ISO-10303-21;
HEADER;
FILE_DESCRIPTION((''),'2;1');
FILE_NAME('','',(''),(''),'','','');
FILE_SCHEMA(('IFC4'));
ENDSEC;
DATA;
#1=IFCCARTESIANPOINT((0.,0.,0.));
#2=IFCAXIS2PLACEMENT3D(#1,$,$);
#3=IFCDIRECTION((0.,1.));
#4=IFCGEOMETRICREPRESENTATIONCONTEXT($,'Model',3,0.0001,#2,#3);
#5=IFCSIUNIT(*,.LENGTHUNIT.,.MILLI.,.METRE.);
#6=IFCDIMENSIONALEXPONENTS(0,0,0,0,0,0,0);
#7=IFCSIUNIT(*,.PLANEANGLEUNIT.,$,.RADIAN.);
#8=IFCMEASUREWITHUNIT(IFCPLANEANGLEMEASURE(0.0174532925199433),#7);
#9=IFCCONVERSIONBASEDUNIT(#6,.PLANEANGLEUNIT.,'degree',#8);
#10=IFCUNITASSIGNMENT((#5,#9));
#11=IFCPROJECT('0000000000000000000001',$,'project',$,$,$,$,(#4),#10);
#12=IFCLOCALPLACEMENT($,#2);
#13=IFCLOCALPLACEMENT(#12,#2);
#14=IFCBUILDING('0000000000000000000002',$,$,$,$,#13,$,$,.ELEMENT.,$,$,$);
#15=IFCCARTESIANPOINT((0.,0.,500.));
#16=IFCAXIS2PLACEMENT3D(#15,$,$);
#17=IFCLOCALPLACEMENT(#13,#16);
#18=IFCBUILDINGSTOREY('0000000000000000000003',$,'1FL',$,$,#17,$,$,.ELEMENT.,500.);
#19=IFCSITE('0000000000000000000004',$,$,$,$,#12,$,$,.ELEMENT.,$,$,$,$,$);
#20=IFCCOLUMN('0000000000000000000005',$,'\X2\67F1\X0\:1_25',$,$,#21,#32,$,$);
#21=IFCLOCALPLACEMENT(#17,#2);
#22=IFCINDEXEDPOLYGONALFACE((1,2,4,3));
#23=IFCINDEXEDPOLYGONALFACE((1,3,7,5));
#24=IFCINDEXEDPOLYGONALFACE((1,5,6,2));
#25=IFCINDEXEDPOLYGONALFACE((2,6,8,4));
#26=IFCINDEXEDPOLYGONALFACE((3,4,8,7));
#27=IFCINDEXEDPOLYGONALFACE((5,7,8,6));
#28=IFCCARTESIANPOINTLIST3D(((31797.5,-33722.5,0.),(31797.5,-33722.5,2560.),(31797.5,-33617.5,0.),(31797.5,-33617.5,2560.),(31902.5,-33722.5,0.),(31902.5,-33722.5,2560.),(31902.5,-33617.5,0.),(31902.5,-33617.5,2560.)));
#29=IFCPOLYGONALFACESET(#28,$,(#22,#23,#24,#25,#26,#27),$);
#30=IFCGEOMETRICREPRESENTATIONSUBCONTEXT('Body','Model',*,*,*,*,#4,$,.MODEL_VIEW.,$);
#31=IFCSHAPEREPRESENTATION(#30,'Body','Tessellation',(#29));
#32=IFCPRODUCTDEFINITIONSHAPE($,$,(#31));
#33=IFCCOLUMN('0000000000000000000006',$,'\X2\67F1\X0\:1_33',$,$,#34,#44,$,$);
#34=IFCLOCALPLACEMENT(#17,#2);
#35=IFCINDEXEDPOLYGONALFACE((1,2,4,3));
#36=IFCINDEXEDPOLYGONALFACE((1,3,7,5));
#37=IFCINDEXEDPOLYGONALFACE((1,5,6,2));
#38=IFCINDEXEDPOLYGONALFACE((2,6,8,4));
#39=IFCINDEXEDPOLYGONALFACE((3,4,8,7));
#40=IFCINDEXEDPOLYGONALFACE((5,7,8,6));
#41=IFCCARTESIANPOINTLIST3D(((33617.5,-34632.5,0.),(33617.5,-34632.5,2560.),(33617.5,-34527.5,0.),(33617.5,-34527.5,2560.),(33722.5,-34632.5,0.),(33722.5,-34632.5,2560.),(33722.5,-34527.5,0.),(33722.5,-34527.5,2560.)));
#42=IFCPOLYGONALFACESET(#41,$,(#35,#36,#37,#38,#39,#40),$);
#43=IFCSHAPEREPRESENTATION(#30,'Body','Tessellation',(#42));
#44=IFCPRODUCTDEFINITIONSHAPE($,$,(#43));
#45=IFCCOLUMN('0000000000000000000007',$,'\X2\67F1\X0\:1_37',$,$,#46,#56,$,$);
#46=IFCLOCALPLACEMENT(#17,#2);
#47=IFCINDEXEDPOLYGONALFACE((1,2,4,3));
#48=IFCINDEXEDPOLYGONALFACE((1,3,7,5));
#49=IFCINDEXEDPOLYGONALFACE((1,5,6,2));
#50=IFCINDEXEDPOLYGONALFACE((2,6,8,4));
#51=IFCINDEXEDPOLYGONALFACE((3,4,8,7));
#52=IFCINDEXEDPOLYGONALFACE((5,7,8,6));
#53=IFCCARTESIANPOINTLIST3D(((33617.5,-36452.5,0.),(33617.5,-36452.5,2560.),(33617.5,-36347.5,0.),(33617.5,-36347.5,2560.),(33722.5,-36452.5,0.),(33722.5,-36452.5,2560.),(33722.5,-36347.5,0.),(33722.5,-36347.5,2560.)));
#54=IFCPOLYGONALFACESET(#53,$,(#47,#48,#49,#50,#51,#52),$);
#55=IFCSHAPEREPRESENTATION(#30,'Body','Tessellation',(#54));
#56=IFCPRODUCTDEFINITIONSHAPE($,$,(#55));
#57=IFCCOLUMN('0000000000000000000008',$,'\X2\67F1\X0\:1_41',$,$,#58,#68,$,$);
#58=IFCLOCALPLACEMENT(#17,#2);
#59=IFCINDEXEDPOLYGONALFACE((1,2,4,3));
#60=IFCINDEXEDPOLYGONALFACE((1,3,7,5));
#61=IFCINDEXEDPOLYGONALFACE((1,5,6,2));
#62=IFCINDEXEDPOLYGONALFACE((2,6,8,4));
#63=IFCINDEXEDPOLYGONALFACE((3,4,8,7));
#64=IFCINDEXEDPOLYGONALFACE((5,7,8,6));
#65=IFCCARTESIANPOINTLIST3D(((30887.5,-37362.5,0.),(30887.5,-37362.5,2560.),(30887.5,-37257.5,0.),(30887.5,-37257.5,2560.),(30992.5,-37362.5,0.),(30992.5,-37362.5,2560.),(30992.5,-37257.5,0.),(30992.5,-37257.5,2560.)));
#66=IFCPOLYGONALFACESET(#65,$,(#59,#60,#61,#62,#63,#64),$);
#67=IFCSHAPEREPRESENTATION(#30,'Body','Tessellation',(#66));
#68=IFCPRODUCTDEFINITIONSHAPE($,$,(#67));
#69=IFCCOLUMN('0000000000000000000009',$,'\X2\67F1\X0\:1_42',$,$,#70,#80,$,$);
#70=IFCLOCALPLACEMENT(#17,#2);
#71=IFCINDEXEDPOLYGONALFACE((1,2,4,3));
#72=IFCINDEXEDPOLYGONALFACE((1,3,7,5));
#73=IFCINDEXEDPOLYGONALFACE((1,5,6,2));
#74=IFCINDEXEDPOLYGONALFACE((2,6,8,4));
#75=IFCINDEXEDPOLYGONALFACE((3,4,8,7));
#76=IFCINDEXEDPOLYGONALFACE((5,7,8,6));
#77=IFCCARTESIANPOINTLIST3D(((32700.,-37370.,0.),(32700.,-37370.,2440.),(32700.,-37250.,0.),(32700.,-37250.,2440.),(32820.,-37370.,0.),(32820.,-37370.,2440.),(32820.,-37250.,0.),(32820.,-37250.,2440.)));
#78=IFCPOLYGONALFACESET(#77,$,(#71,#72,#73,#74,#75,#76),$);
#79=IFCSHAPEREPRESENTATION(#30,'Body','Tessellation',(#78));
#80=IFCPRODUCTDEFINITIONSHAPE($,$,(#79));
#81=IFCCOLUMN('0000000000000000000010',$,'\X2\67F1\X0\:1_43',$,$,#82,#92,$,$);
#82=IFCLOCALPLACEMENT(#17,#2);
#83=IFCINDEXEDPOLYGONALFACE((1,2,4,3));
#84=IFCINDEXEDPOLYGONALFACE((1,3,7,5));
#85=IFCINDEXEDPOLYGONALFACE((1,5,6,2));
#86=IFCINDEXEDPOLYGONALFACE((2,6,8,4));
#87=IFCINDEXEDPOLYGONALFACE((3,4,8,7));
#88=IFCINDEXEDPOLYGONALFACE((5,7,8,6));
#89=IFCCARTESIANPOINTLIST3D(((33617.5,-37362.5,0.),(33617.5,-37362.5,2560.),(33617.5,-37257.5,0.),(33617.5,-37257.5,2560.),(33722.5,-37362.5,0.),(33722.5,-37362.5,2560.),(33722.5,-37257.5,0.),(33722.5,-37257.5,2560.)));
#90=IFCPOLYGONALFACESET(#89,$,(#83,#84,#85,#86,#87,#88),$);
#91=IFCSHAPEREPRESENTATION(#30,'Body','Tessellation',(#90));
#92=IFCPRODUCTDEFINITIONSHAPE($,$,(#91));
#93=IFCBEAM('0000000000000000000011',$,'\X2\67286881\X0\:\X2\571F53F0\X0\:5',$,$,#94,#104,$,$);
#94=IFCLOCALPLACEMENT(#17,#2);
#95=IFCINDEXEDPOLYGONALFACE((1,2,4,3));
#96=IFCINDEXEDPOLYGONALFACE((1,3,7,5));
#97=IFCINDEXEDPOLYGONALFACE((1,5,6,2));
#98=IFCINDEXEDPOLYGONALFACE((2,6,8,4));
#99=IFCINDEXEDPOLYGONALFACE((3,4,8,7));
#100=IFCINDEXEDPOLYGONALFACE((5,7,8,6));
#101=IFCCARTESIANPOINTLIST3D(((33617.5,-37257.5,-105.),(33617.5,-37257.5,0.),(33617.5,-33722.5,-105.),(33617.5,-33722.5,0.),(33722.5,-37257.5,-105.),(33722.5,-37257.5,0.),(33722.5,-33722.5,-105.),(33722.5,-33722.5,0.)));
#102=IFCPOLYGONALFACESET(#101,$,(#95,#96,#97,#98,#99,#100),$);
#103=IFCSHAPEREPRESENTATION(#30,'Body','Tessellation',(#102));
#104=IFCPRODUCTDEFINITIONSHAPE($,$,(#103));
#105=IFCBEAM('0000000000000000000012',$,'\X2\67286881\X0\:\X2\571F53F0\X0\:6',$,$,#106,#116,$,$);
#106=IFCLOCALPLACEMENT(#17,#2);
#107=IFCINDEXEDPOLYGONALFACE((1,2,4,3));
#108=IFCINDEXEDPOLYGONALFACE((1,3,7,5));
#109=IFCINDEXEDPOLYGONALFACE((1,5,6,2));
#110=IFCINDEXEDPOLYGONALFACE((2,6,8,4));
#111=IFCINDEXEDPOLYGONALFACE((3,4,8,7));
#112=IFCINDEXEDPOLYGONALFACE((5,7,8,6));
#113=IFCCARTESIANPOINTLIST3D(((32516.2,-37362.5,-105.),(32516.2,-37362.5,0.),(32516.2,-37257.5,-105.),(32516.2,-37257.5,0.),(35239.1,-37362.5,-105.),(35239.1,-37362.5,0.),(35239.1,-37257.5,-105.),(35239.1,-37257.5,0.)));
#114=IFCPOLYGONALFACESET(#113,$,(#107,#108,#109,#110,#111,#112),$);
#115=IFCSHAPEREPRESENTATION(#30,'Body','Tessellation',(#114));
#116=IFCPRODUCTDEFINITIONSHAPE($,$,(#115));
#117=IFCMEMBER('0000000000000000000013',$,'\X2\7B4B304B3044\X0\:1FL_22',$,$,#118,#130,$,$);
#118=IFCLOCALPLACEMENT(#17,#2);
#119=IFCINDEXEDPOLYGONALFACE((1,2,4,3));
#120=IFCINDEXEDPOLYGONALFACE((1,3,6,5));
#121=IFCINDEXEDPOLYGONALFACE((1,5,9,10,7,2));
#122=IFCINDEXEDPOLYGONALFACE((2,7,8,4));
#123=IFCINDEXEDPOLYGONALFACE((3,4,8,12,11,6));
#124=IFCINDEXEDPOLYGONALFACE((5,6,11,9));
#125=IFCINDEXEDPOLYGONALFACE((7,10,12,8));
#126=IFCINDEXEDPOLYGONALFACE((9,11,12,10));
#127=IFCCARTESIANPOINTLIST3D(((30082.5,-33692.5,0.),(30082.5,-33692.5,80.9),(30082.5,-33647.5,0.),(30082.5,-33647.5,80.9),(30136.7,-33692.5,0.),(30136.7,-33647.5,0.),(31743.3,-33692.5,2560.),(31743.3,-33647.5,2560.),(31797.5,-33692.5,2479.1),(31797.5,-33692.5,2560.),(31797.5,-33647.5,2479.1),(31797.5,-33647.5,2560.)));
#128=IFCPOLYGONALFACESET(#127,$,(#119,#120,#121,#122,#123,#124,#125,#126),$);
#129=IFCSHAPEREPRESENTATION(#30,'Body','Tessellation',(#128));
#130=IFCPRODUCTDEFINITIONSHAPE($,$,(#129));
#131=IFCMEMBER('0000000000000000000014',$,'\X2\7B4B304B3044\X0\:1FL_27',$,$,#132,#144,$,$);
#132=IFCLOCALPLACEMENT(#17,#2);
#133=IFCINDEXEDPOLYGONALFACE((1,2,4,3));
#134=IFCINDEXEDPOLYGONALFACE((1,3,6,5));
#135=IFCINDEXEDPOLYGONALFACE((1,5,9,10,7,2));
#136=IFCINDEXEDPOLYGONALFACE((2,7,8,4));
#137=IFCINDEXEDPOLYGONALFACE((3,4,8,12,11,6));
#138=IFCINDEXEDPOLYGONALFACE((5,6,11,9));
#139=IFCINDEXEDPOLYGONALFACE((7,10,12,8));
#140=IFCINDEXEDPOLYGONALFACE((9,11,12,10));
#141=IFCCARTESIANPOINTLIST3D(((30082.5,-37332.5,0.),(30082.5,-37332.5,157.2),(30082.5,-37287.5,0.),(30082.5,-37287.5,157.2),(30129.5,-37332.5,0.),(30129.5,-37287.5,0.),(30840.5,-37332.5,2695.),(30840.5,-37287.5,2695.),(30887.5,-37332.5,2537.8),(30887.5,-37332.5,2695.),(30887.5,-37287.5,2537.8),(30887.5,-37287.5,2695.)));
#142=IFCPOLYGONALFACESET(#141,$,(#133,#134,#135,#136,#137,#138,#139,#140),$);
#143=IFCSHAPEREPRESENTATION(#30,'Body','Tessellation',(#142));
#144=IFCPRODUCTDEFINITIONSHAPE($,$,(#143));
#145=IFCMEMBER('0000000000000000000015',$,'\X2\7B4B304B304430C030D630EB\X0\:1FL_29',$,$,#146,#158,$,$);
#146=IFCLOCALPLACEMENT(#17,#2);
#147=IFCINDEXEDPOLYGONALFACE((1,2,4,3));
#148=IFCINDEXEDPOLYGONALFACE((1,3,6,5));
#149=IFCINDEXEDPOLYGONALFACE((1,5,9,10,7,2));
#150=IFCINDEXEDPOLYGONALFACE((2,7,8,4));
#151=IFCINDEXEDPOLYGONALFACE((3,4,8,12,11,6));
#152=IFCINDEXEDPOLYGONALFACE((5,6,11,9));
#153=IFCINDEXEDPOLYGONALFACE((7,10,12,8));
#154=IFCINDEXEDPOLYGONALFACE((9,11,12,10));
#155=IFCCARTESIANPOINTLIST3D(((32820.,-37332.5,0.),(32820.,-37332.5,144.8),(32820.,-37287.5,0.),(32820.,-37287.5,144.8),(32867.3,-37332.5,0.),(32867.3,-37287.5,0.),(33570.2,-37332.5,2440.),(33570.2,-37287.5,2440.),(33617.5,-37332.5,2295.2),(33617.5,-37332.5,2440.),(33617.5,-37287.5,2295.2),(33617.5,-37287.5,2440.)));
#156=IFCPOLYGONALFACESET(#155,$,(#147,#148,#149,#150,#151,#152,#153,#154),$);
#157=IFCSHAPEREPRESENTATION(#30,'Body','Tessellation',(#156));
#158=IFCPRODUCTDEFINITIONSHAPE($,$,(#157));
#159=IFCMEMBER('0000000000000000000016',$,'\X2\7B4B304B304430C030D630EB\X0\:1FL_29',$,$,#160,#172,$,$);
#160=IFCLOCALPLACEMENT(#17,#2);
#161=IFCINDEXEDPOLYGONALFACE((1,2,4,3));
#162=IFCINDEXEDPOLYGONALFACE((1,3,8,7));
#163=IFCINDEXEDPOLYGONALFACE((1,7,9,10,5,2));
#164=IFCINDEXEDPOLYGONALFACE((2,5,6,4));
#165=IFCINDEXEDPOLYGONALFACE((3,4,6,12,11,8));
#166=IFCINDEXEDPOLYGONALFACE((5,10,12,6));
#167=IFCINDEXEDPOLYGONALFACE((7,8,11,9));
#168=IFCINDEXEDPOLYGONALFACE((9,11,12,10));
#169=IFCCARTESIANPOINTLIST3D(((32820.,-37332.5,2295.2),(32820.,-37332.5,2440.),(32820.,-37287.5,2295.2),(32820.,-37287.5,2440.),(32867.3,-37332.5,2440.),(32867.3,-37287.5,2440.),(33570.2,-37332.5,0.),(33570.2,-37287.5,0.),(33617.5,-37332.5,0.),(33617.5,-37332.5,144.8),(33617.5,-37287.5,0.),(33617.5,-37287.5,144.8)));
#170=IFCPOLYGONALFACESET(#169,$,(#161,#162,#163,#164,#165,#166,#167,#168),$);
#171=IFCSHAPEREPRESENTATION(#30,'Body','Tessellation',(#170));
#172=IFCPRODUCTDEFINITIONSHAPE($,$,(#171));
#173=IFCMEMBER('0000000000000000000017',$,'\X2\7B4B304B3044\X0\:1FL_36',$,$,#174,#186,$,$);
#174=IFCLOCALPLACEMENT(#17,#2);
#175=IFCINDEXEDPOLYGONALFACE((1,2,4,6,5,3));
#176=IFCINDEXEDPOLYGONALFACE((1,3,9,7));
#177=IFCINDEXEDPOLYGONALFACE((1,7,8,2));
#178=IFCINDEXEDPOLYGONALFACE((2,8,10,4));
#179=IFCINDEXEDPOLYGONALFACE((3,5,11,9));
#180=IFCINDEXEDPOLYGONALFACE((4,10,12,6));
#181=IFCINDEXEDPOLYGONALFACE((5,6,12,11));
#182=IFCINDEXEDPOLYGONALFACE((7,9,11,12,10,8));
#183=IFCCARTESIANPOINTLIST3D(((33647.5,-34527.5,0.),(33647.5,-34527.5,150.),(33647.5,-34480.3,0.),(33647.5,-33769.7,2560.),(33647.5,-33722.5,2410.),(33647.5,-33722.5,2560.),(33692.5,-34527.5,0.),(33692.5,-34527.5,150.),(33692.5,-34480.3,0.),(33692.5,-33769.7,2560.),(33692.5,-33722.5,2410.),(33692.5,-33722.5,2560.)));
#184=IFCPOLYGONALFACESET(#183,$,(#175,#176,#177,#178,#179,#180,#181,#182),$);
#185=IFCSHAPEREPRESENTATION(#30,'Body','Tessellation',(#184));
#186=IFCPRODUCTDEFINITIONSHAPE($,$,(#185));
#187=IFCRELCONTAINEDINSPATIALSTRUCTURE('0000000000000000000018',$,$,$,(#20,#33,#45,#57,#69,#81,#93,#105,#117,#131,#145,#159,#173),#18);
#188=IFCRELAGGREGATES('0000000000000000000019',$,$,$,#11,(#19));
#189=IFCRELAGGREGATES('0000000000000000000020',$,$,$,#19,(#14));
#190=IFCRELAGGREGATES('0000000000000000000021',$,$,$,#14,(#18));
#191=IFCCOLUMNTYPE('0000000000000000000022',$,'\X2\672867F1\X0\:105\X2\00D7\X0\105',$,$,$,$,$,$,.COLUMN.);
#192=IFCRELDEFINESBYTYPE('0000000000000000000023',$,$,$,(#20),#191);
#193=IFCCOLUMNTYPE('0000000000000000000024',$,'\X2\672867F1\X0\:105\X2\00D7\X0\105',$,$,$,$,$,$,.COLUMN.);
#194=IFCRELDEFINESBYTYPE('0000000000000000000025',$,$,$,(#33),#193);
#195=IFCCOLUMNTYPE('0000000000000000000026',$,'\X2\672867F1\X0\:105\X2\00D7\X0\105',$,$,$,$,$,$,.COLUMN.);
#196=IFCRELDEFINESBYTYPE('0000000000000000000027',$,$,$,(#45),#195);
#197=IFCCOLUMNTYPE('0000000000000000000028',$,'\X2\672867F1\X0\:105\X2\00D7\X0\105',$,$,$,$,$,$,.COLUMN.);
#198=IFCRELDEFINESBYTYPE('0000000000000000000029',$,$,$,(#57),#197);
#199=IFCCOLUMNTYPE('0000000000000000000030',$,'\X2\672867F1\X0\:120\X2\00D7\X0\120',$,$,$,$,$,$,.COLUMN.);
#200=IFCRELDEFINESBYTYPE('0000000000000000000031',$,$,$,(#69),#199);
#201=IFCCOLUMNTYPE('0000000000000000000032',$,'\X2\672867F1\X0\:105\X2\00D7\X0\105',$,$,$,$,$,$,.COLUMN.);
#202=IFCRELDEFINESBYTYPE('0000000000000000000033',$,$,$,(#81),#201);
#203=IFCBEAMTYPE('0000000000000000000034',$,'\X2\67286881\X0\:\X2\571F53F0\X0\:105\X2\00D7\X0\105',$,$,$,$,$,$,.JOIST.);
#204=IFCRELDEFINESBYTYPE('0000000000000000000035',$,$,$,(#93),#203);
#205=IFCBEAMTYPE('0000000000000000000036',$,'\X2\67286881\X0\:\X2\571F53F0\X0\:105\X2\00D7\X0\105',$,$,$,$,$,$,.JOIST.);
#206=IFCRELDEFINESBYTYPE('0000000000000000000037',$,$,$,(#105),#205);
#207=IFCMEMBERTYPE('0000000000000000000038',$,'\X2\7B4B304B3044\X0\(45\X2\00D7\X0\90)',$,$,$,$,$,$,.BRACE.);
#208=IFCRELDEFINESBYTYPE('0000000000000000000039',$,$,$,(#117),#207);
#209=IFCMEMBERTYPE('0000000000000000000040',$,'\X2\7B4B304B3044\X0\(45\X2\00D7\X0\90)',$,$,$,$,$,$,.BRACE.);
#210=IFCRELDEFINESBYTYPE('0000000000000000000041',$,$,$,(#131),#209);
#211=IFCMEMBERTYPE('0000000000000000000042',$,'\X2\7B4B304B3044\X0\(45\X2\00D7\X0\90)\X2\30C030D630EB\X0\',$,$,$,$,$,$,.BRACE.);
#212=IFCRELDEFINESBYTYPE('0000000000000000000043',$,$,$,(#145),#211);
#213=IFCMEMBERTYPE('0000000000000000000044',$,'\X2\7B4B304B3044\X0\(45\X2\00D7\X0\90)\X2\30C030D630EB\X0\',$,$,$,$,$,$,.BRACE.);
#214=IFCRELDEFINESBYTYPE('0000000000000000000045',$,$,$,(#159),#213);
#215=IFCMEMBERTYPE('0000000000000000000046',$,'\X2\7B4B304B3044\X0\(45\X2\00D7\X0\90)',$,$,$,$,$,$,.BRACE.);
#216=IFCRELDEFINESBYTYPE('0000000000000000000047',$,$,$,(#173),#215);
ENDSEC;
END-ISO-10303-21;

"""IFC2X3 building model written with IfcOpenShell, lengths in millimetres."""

from ifc_helpers import new_model, entity, si_unit, converted_unit, direction, frame, origin, origin_with_axes, origin_2d, place, context, subcontext, project, spatial, polyline, rectangle, outline, extrude, type_object, element, save


model = new_model("IFC2X3")

# Units and contexts
model_context = context("Model", 3, precision=0.0001, world=origin(), true_north=direction((0.0, 1.0)))
body_context = subcontext(model_context, "Body", "Model", "MODEL_VIEW")
ifc_project = project(units=[si_unit("LENGTHUNIT", "METRE", prefix="MILLI"), converted_unit("PLANEANGLEUNIT", "degree", entity("IfcPlaneAngleMeasure", 0.0174532925199433), si_unit("PLANEANGLEUNIT", "RADIAN"), dimensions=[0, 0, 0, 0, 0, 0, 0])], contexts=[model_context])

# Site, building, storey
site_placement = place(None, origin())
site = spatial("IfcSite", under=ifc_project, at=site_placement, CompositionType="ELEMENT")
building_placement = place(site_placement, origin())
building = spatial("IfcBuilding", under=site, at=building_placement, CompositionType="ELEMENT")
storey_placement = place(building_placement, frame((0.0, 0.0, 500.0)))
storey = spatial("IfcBuildingStorey", under=building, at=storey_placement, Name="1FL", CompositionType="ELEMENT", Elevation=500.0)

# Columns
column_type_1 = type_object("IfcColumnType", Name="木柱:105×105", PredefinedType="COLUMN")
column_1_placement = place(storey_placement, frame((31850.0, -33670.0, 0.0)))
element("IfcColumn", 1, at=column_1_placement, inside=storey, type_object=column_type_1, Name="柱:1_25", context=body_context, shape_type="SweptSolid", body=[
    extrude(rectangle(XDim=105.0, YDim=105.0, at=origin_2d()), origin_with_axes(), (0.0, 0.0, 1.0), 2560.0),
])
column_type_2 = type_object("IfcColumnType", Name="木柱:105×105", PredefinedType="COLUMN")
column_2_placement = place(storey_placement, frame((33670.0, -34580.0, 0.0)))
element("IfcColumn", 2, at=column_2_placement, inside=storey, type_object=column_type_2, Name="柱:1_33", context=body_context, shape_type="SweptSolid", body=[
    extrude(rectangle(XDim=105.0, YDim=105.0, at=origin_2d()), origin_with_axes(), (0.0, 0.0, 1.0), 2560.0),
])
column_type_3 = type_object("IfcColumnType", Name="木柱:105×105", PredefinedType="COLUMN")
column_3_placement = place(storey_placement, frame((33670.0, -36400.0, 0.0)))
element("IfcColumn", 3, at=column_3_placement, inside=storey, type_object=column_type_3, Name="柱:1_37", context=body_context, shape_type="SweptSolid", body=[
    extrude(rectangle(XDim=105.0, YDim=105.0, at=origin_2d()), origin_with_axes(), (0.0, 0.0, 1.0), 2560.0),
])
column_type_4 = type_object("IfcColumnType", Name="木柱:105×105", PredefinedType="COLUMN")
column_4_placement = place(storey_placement, frame((30940.0, -37310.0, 0.0)))
element("IfcColumn", 4, at=column_4_placement, inside=storey, type_object=column_type_4, Name="柱:1_41", context=body_context, shape_type="SweptSolid", body=[
    extrude(rectangle(XDim=105.0, YDim=105.0, at=origin_2d()), origin_with_axes(), (0.0, 0.0, 1.0), 2560.0),
])
column_type_5 = type_object("IfcColumnType", Name="木柱:120×120", PredefinedType="COLUMN")
column_5_placement = place(storey_placement, frame((32760.0, -37310.0, 0.0)))
element("IfcColumn", 5, at=column_5_placement, inside=storey, type_object=column_type_5, Name="柱:1_42", context=body_context, shape_type="SweptSolid", body=[
    extrude(rectangle(XDim=120.0, YDim=120.0, at=origin_2d()), origin_with_axes(), (0.0, 0.0, 1.0), 2440.0),
])
column_type_6 = type_object("IfcColumnType", Name="木柱:105×105", PredefinedType="COLUMN")
column_6_placement = place(storey_placement, frame((33670.0, -37310.0, 0.0)))
element("IfcColumn", 6, at=column_6_placement, inside=storey, type_object=column_type_6, Name="柱:1_43", context=body_context, shape_type="SweptSolid", body=[
    extrude(rectangle(XDim=105.0, YDim=105.0, at=origin_2d()), origin_with_axes(), (0.0, 0.0, 1.0), 2560.0),
])

# Beams
beam_type_1 = type_object("IfcBeamType", Name="木梁:土台:105×105", PredefinedType="JOIST")
beam_1_placement = place(storey_placement, frame((33670.0, -33722.5, -52.5), z_axis=(0.0, -1.0, 0.0), x_axis=(1.0, 0.0, 0.0)))
element("IfcBeam", 7, at=beam_1_placement, inside=storey, type_object=beam_type_1, Name="木梁:土台:5", context=body_context, shape_type="SweptSolid", body=[
    extrude(rectangle(XDim=105.0, YDim=105.0, at=origin_2d()), origin_with_axes(), (0.0, 0.0, 1.0), 3535.0),
])
beam_type_2 = type_object("IfcBeamType", Name="木梁:土台:105×105", PredefinedType="JOIST")
beam_2_placement = place(storey_placement, frame((32516.2, -37310.0, -52.5), z_axis=(1.0, 0.0, 0.0), x_axis=(0.0, 1.0, 0.0)))
element("IfcBeam", 8, at=beam_2_placement, inside=storey, type_object=beam_type_2, Name="木梁:土台:6", context=body_context, shape_type="SweptSolid", body=[
    extrude(rectangle(XDim=105.0, YDim=105.0, at=origin_2d()), origin_with_axes(), (0.0, 0.0, 1.0), 2722.9),
])

# Members
member_type_1 = type_object("IfcMemberType", Name="筋かい(45×90)", PredefinedType="BRACE")
member_1_placement = place(storey_placement, frame((30082.5, -33670.0, 0.0), z_axis=(0.556571, 0.0, 0.8308), x_axis=(-0.8308, 0.0, 0.556571)))
element("IfcMember", 9, at=member_1_placement, inside=storey, type_object=member_type_1, Name="筋かい:1FL_22", context=body_context, shape_type="SweptSolid", body=[
    extrude(outline(polyline([(0.0, 0.0), (30.1, -45.0), (3014.2, -45.0), (3081.4, 0.0), (3051.2, 45.0), (67.2, 45.0), (0.0, 0.0)])), frame((0.0, -22.5, 0.0), z_axis=(0.0, 1.0, 0.0), x_axis=(0.0, 0.0, 1.0)), (0.0, 0.0, 1.0), 45.0),
])
member_type_2 = type_object("IfcMemberType", Name="筋かい(45×90)", PredefinedType="BRACE")
member_2_placement = place(storey_placement, frame((30082.5, -37310.0, 0.0), z_axis=(0.286206, 0.0, 0.958168), x_axis=(-0.958168, 0.0, 0.286206)))
element("IfcMember", 10, at=member_2_placement, inside=storey, type_object=member_type_2, Name="筋かい:1FL_27", context=body_context, shape_type="SweptSolid", body=[
    extrude(outline(polyline([(0.0, 0.0), (13.4, -45.0), (2662.0, -45.0), (2812.7, 0.0), (2799.2, 45.0), (150.7, 45.0), (0.0, 0.0)])), frame((0.0, -22.5, 0.0), z_axis=(0.0, 1.0, 0.0), x_axis=(0.0, 0.0, 1.0)), (0.0, 0.0, 1.0), 45.0),
])
member_type_3 = type_object("IfcMemberType", Name="筋かい(45×90)ダブル", PredefinedType="BRACE")
member_3_placement = place(storey_placement, frame((32820.0, -37310.0, 0.0), z_axis=(0.310671, 0.0, 0.950517), x_axis=(-0.950517, 0.0, 0.310671)))
element("IfcMember", 11, at=member_3_placement, inside=storey, type_object=member_type_3, Name="筋かいダブル:1FL_29", context=body_context, shape_type="SweptSolid", body=[
    extrude(outline(polyline([(0.0, 0.0), (14.7, -45.0), (2429.3, -45.0), (2567.0, 0.0), (2552.3, 45.0), (137.7, 45.0), (0.0, 0.0)])), frame((0.0, -22.5, 0.0), z_axis=(0.0, 1.0, 0.0), x_axis=(0.0, 0.0, 1.0)), (0.0, 0.0, 1.0), 45.0),
])
member_type_4 = type_object("IfcMemberType", Name="筋かい(45×90)ダブル", PredefinedType="BRACE")
member_4_placement = place(storey_placement, frame((33617.5, -37310.0, 0.0), z_axis=(-0.310671, 0.0, 0.950517), x_axis=(0.950517, 0.0, 0.310671)))
element("IfcMember", 12, at=member_4_placement, inside=storey, type_object=member_type_4, Name="筋かいダブル:1FL_29", context=body_context, shape_type="SweptSolid", body=[
    extrude(outline(polyline([(0.0, 0.0), (14.7, -45.0), (2429.3, -45.0), (2567.0, 0.0), (2552.3, 45.0), (137.7, 45.0), (0.0, 0.0)])), frame((0.0, -22.5, 0.0), z_axis=(0.0, 1.0, 0.0), x_axis=(0.0, 0.0, 1.0)), (0.0, 0.0, 1.0), 45.0),
])
member_type_5 = type_object("IfcMemberType", Name="筋かい(45×90)", PredefinedType="BRACE")
member_5_placement = place(storey_placement, frame((33670.0, -34527.5, 0.0), z_axis=(0.0, 0.299972, 0.953948), x_axis=(0.0, -0.953948, 0.299972)))
element("IfcMember", 13, at=member_5_placement, inside=storey, type_object=member_type_5, Name="筋かい:1FL_36", context=body_context, shape_type="SweptSolid", body=[
    extrude(outline(polyline([(0.0, 0.0), (14.2, -45.0), (2540.5, -45.0), (2683.6, 0.0), (2669.4, 45.0), (143.1, 45.0), (0.0, 0.0)])), frame((0.0, -22.5, 0.0), z_axis=(0.0, 1.0, 0.0), x_axis=(0.0, 0.0, 1.0)), (0.0, 0.0, 1.0), 45.0),
])

save(model, "model.ifc")
